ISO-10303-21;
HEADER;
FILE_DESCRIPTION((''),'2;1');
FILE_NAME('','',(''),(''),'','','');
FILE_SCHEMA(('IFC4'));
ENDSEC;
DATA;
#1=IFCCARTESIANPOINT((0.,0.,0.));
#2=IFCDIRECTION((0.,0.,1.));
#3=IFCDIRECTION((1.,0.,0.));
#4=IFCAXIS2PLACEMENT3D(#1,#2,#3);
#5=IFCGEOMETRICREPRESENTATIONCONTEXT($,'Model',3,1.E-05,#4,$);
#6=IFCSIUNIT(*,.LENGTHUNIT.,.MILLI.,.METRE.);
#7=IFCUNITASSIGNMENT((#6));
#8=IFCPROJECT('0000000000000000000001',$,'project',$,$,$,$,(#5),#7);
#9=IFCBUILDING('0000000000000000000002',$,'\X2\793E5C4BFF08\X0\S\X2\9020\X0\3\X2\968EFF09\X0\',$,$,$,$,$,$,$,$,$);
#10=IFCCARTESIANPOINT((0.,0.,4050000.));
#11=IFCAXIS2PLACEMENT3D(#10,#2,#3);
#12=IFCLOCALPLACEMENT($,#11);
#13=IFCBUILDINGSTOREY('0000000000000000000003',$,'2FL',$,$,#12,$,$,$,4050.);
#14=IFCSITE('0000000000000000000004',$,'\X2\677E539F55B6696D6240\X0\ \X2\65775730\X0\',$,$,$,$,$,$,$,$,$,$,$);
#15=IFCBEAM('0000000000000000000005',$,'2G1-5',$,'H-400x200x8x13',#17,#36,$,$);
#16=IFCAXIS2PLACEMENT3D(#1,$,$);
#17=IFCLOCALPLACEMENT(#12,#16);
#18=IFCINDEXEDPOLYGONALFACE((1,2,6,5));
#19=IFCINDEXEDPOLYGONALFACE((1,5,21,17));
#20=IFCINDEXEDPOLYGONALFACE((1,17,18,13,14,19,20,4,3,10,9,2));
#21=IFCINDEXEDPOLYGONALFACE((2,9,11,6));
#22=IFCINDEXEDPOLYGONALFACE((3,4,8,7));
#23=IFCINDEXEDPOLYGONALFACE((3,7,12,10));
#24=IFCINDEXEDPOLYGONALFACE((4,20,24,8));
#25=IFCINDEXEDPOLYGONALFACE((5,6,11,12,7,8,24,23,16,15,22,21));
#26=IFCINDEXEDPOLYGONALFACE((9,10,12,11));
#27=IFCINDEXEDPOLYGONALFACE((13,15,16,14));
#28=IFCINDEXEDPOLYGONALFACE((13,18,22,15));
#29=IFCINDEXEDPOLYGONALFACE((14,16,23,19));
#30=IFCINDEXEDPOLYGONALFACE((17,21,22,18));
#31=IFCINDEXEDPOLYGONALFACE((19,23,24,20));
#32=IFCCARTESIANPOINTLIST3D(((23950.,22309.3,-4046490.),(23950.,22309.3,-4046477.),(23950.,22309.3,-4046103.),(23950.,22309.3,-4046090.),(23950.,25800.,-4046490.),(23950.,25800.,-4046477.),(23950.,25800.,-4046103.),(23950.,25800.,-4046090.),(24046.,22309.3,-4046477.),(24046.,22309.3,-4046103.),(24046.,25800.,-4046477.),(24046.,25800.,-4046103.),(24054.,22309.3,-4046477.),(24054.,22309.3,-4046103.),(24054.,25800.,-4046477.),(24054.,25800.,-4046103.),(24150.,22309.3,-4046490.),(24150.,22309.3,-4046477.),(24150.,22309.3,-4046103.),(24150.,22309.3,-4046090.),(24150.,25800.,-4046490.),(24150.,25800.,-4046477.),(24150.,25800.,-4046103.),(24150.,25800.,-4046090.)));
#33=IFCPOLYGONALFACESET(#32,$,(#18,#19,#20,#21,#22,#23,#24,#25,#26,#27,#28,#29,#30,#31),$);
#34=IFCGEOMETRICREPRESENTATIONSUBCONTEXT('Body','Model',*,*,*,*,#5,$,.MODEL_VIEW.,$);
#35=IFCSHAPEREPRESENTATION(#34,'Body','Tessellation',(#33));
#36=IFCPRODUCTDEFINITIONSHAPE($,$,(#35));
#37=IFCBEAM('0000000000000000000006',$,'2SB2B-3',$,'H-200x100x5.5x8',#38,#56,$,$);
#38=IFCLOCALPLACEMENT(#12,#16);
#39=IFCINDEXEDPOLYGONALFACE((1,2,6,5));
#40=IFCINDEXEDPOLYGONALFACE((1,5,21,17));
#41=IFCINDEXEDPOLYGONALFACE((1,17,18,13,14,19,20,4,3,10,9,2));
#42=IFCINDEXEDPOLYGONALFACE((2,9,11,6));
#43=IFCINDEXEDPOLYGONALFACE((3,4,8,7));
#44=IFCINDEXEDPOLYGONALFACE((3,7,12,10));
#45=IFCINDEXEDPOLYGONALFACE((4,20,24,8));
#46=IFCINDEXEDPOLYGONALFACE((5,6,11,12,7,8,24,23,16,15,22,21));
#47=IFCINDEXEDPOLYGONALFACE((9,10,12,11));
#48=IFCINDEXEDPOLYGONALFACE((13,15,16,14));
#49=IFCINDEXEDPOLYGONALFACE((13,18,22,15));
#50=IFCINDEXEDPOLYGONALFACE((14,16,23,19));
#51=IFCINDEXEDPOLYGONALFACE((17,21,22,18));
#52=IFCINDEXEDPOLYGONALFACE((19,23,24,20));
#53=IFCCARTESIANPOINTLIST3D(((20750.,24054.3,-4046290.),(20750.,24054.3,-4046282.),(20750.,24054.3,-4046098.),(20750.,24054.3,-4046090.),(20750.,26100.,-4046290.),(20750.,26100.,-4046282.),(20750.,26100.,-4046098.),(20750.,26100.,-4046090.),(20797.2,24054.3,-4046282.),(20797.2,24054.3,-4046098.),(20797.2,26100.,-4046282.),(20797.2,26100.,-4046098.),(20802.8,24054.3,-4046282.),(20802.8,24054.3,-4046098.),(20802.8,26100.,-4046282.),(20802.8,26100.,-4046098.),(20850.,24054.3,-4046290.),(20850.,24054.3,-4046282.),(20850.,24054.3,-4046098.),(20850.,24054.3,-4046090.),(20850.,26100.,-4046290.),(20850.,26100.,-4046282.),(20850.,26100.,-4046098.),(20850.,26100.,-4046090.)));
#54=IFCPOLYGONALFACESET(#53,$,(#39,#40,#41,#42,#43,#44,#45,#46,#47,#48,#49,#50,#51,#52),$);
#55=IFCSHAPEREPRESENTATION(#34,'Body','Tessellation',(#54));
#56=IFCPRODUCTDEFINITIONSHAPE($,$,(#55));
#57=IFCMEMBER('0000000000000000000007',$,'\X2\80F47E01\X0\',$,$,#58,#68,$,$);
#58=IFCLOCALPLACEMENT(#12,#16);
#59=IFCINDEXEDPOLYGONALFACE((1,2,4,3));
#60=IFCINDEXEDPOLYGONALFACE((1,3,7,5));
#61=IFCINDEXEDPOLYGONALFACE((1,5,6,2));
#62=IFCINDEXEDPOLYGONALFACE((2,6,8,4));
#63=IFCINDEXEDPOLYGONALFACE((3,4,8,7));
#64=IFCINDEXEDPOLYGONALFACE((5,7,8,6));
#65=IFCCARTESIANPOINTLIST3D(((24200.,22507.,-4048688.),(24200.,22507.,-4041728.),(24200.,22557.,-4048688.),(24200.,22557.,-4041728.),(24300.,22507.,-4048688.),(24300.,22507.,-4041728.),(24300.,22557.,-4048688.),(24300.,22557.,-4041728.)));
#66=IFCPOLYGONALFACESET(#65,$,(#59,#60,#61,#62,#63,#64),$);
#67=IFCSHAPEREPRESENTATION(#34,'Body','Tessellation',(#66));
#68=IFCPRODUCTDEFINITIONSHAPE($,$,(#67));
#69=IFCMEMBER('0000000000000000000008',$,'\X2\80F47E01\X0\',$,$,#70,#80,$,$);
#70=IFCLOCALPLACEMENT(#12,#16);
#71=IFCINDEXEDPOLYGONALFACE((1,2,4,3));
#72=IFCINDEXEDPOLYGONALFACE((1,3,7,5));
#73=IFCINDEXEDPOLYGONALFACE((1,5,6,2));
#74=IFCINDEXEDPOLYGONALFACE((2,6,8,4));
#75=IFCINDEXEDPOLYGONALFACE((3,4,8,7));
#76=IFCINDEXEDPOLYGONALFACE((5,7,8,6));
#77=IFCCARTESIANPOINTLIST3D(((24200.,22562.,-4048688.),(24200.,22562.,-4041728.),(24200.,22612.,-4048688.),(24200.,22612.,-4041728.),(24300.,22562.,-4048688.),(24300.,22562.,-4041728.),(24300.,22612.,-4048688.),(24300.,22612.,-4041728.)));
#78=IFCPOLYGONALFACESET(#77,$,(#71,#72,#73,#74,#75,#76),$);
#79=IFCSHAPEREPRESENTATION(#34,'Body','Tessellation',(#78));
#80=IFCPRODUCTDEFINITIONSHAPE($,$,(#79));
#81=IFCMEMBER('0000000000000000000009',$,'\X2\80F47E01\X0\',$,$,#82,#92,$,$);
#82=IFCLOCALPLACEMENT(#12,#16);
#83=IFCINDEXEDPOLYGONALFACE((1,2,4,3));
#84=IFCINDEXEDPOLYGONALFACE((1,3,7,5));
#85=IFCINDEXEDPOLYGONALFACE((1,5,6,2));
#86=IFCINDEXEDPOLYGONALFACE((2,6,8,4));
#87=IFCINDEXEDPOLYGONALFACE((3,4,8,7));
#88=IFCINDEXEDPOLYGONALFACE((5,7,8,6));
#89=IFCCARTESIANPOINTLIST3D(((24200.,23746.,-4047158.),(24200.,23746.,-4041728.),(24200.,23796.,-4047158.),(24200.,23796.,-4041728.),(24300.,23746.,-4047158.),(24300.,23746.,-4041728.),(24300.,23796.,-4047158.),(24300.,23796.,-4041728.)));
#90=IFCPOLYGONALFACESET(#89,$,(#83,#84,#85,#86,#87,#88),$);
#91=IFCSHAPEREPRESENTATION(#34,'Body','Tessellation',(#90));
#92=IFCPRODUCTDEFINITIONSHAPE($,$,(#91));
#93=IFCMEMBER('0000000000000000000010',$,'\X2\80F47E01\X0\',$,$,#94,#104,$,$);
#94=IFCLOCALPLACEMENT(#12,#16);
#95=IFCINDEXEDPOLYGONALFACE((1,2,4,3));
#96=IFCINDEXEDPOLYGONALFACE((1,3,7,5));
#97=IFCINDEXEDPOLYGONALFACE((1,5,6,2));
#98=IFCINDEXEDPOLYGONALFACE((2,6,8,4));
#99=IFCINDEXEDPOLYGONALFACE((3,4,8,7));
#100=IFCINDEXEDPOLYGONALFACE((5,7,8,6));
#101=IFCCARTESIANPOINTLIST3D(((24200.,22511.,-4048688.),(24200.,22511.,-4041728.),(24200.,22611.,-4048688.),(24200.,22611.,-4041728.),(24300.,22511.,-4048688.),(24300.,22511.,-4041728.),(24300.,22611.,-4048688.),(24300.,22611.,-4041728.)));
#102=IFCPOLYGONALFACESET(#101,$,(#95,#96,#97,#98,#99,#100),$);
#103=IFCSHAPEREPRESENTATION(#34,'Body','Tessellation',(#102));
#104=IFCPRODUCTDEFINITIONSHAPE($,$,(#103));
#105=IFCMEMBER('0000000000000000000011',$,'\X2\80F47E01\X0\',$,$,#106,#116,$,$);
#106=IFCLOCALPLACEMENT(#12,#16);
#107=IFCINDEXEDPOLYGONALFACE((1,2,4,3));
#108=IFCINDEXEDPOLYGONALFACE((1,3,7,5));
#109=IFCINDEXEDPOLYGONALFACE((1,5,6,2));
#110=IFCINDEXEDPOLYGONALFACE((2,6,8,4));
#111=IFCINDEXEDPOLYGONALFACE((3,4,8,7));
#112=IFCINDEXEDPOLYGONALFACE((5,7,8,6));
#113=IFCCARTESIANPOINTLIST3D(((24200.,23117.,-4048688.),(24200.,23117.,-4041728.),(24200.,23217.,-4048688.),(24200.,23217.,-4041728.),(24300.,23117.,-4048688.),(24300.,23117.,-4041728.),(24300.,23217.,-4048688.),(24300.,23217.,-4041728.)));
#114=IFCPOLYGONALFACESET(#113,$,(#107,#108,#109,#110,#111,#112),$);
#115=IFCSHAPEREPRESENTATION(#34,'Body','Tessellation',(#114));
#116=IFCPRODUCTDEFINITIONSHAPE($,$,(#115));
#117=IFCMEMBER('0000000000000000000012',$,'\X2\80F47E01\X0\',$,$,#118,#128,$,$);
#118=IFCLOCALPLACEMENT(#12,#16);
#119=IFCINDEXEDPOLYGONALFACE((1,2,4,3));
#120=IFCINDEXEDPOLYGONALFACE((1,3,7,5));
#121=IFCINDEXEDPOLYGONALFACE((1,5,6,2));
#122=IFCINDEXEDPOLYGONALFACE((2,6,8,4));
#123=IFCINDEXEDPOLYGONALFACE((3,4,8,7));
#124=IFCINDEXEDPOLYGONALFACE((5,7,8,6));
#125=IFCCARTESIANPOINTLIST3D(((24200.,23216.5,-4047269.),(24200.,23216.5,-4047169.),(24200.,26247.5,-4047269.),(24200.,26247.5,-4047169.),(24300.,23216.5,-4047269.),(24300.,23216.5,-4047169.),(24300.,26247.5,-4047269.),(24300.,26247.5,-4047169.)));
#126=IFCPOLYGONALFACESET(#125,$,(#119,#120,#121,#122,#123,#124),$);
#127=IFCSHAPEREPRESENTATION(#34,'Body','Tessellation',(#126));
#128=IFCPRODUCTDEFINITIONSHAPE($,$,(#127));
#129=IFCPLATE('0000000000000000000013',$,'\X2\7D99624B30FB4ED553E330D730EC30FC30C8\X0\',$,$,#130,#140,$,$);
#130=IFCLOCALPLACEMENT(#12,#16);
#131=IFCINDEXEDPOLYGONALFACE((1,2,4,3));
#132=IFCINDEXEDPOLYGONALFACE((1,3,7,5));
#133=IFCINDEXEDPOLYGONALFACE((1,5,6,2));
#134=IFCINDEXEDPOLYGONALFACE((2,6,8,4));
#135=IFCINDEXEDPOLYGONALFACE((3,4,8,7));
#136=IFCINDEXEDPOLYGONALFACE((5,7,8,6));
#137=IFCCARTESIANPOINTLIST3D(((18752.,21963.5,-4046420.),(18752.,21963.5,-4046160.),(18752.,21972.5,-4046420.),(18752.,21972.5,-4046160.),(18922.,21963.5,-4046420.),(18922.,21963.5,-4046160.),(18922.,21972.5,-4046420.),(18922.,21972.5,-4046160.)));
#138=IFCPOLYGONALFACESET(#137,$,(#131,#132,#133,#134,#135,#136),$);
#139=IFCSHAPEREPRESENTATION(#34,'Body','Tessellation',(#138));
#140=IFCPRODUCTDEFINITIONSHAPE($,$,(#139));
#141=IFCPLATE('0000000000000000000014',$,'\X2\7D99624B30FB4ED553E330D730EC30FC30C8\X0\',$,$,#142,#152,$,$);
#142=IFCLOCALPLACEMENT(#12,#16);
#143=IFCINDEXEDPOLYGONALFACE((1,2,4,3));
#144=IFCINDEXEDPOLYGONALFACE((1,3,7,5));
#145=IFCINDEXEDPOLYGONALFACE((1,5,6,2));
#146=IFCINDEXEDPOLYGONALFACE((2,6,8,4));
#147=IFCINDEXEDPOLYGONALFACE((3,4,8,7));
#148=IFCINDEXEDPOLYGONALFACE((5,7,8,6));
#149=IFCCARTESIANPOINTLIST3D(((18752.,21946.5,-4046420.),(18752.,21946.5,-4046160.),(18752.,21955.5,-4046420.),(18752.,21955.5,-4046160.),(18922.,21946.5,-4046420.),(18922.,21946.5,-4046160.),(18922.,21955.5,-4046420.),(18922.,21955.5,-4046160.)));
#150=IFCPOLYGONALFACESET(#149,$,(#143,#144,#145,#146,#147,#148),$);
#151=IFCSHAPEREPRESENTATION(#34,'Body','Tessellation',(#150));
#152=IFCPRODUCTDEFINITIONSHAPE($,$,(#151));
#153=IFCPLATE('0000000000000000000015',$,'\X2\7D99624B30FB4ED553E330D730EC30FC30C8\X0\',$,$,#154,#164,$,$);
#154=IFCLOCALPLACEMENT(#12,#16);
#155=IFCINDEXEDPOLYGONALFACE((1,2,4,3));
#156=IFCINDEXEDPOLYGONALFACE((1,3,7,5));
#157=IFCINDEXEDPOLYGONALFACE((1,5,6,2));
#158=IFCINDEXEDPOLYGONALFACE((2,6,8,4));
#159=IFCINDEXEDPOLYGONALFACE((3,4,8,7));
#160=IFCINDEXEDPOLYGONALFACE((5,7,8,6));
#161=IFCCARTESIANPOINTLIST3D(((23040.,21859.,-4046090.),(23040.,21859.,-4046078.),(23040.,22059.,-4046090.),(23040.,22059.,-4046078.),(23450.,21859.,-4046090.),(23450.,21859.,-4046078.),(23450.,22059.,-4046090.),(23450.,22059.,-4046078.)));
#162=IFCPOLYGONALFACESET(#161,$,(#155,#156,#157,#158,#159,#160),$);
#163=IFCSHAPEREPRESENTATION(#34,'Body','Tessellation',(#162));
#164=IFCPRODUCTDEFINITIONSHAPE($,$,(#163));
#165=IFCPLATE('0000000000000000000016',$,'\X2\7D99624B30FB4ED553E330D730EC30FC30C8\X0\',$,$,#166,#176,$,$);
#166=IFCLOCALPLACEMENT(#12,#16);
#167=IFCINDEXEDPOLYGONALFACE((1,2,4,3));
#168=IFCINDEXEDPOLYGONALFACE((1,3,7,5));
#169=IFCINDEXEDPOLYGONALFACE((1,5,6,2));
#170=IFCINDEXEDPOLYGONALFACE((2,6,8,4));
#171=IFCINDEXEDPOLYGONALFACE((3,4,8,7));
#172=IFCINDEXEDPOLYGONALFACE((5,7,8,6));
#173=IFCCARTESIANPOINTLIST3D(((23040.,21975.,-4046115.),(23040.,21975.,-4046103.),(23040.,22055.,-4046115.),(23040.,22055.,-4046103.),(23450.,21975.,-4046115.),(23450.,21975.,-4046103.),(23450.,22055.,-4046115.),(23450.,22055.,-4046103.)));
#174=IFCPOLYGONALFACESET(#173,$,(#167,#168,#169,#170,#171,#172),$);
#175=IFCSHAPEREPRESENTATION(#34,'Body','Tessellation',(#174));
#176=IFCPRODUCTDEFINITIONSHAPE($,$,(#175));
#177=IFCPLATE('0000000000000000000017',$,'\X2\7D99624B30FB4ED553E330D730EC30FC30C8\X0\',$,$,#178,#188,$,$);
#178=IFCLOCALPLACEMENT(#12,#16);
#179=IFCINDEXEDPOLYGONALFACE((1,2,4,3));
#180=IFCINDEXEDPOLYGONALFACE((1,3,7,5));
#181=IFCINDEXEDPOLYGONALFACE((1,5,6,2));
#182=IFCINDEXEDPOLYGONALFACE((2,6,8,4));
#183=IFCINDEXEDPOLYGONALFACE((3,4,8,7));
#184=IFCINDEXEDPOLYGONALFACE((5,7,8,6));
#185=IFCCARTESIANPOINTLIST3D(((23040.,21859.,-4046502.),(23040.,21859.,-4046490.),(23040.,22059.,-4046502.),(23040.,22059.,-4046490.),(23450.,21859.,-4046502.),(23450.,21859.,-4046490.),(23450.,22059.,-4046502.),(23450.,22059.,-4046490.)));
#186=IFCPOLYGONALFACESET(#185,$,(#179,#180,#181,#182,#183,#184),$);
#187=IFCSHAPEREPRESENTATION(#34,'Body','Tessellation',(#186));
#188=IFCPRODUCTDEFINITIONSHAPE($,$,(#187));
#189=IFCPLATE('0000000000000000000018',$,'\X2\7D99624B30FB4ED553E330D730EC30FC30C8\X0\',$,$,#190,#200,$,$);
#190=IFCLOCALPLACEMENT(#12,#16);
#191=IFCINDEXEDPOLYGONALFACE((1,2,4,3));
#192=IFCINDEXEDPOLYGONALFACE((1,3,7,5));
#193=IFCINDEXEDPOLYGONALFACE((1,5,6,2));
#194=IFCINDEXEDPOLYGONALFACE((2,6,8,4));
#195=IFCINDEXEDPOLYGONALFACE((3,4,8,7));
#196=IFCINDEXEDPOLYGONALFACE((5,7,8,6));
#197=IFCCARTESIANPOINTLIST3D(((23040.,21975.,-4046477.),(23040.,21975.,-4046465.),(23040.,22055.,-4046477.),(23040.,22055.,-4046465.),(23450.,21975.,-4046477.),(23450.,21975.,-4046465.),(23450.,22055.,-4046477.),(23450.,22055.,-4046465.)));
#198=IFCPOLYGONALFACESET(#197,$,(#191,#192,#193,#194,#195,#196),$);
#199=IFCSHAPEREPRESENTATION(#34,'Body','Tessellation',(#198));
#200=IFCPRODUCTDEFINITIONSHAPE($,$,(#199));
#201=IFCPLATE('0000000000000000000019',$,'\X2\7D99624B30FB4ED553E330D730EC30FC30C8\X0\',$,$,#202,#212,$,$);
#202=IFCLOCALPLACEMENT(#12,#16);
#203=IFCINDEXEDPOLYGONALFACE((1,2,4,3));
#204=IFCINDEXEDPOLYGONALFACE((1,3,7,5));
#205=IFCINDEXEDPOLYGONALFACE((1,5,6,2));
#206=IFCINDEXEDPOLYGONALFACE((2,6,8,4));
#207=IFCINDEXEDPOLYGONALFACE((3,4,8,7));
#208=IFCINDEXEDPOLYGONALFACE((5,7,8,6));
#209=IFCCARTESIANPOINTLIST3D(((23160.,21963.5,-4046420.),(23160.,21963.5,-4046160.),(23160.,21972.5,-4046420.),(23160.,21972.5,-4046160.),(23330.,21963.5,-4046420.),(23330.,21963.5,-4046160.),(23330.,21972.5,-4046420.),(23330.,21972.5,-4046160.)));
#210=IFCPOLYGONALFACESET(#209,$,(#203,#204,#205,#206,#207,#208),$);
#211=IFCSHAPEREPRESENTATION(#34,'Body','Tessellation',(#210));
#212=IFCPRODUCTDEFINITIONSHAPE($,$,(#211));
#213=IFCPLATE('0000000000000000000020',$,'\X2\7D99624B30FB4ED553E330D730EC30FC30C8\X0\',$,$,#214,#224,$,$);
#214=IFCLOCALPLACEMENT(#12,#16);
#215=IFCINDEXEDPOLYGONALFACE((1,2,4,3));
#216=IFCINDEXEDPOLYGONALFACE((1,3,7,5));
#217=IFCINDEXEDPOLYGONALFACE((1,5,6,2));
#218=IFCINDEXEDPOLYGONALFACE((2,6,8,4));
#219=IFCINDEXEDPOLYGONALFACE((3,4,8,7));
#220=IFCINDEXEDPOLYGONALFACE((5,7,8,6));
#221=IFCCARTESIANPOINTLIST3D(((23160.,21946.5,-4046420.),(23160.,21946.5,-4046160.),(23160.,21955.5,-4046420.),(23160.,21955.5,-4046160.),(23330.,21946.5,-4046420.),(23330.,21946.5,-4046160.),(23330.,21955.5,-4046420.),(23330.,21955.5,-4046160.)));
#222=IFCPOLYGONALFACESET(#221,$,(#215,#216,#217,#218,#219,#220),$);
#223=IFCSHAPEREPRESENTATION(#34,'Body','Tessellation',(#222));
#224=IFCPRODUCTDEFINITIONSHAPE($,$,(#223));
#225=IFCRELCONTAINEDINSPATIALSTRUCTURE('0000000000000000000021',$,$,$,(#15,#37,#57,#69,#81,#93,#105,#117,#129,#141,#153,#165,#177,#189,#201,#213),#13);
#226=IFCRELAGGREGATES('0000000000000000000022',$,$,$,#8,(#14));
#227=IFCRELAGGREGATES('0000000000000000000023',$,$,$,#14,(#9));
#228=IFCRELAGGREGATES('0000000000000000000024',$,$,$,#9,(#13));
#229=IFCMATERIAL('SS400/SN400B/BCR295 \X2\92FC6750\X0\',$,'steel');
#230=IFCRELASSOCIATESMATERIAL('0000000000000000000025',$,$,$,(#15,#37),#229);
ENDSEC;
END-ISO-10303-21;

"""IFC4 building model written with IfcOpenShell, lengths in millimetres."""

from ifc_helpers import new_model, si_unit, frame, origin, origin_with_axes, place, context, subcontext, project, spatial, rectangle, i_section, extrude, material, element, save


model = new_model("IFC4")

# Units and contexts
model_context = context("Model", 3, precision=1e-05, world=origin_with_axes())
body_context = subcontext(model_context, "Body", "Model", "MODEL_VIEW")
ifc_project = project(units=[si_unit("LENGTHUNIT", "METRE", prefix="MILLI")], contexts=[model_context])

# Site, building, storey
site = spatial("IfcSite", under=ifc_project, Name="松原営業所 敷地")
building = spatial("IfcBuilding", under=site, Name="社屋（S造3階）")
storey_placement = place(None, frame((0.0, 0.0, 4050000.0), z_axis=(0.0, 0.0, 1.0), x_axis=(1.0, 0.0, 0.0)))
storey = spatial("IfcBuildingStorey", under=building, at=storey_placement, Name="2FL", Elevation=4050.0)

# Beams
ifc_material = material(Name="SS400/SN400B/BCR295 鋼材", Category="steel")
beam_1_placement = place(storey_placement, frame((24050.0, 22309.3, -4046090.0), z_axis=(0.0, 1.0, 0.0), x_axis=(-1.0, 0.0, 0.0)))
element("IfcBeam", 1, at=beam_1_placement, inside=storey, material=ifc_material, Name="2G1-5", ObjectType="H-400x200x8x13", context=body_context, shape_type="SweptSolid", body=[
    extrude(i_section(OverallWidth=200.0, OverallDepth=400.0, WebThickness=8.0, FlangeThickness=13.0), frame((0.0, -200.0, 0.0)), (0.0, 0.0, 1.0), 3490.7),
])
beam_2_placement = place(storey_placement, frame((20800.0, 24054.3, -4046090.0), z_axis=(0.0, 1.0, 0.0), x_axis=(-1.0, 0.0, 0.0)))
element("IfcBeam", 2, at=beam_2_placement, inside=storey, material=ifc_material, Name="2SB2B-3", ObjectType="H-200x100x5.5x8", context=body_context, shape_type="SweptSolid", body=[
    extrude(i_section(OverallWidth=100.0, OverallDepth=200.0, WebThickness=5.5, FlangeThickness=8.0), frame((0.0, -100.0, 0.0)), (0.0, 0.0, 1.0), 2045.7),
])

# Members
for number, where, z_axis, x_axis, name in (
    (3, (24250.0, 22507.0, -4045208.0), (0.0, 1.0, 0.0), (-1.0, 0.0, 0.0), "胴縁"),
    (4, (24250.0, 22562.0, -4045208.0), (0.0, 1.0, 0.0), (-1.0, 0.0, 0.0), "胴縁"),
):
    element("IfcMember", number, at=place(storey_placement, frame(where, z_axis=z_axis, x_axis=x_axis)), inside=storey, Name=name, context=body_context, shape_type="SweptSolid", body=[
        extrude(rectangle(XDim=100.0, YDim=6960.0), origin(), (0.0, 0.0, 1.0), 50.0),
    ])
member_1_placement = place(storey_placement, frame((24250.0, 23746.0, -4044443.0), z_axis=(0.0, 1.0, 0.0), x_axis=(-1.0, 0.0, 0.0)))
element("IfcMember", 5, at=member_1_placement, inside=storey, Name="胴縁", context=body_context, shape_type="SweptSolid", body=[
    extrude(rectangle(XDim=100.0, YDim=5430.0), origin(), (0.0, 0.0, 1.0), 50.0),
])
for number, where, z_axis, x_axis, name in (
    (6, (24250.0, 22511.0, -4045208.0), (0.0, 1.0, 0.0), (-1.0, 0.0, 0.0), "胴縁"),
    (7, (24250.0, 23117.0, -4045208.0), (0.0, 1.0, 0.0), (-1.0, 0.0, 0.0), "胴縁"),
):
    element("IfcMember", number, at=place(storey_placement, frame(where, z_axis=z_axis, x_axis=x_axis)), inside=storey, Name=name, context=body_context, shape_type="SweptSolid", body=[
        extrude(rectangle(XDim=100.0, YDim=6960.0), origin(), (0.0, 0.0, 1.0), 100.0),
    ])
member_2_placement = place(storey_placement, frame((24250.0, 23216.5, -4047219.0), z_axis=(0.0, 1.0, 0.0), x_axis=(-1.0, 0.0, 0.0)))
element("IfcMember", 8, at=member_2_placement, inside=storey, Name="胴縁", context=body_context, shape_type="SweptSolid", body=[
    extrude(rectangle(XDim=100.0, YDim=100.0), origin(), (0.0, 0.0, 1.0), 3031.0),
])

# Plates
for number, where, z_axis, x_axis, name in (
    (9, (18752.0, 21968.0, -4046290.0), (1.0, 0.0, 0.0), (0.0, 1.0, 0.0), "継手・仕口プレート"),
    (10, (18752.0, 21951.0, -4046290.0), (1.0, 0.0, 0.0), (0.0, 1.0, 0.0), "継手・仕口プレート"),
):
    element("IfcPlate", number, at=place(storey_placement, frame(where, z_axis=z_axis, x_axis=x_axis)), inside=storey, Name=name, context=body_context, shape_type="SweptSolid", body=[
        extrude(rectangle(XDim=9.0, YDim=260.0), origin(), (0.0, 0.0, 1.0), 170.0),
    ])
plate_1_placement = place(storey_placement, frame((23040.0, 21959.0, -4046084.0), z_axis=(1.0, 0.0, 0.0), x_axis=(0.0, 1.0, 0.0)))
element("IfcPlate", 11, at=plate_1_placement, inside=storey, Name="継手・仕口プレート", context=body_context, shape_type="SweptSolid", body=[
    extrude(rectangle(XDim=200.0, YDim=12.0), origin(), (0.0, 0.0, 1.0), 410.0),
])
plate_2_placement = place(storey_placement, frame((23040.0, 22015.0, -4046109.0), z_axis=(1.0, 0.0, 0.0), x_axis=(0.0, 1.0, 0.0)))
element("IfcPlate", 12, at=plate_2_placement, inside=storey, Name="継手・仕口プレート", context=body_context, shape_type="SweptSolid", body=[
    extrude(rectangle(XDim=80.0, YDim=12.0), origin(), (0.0, 0.0, 1.0), 410.0),
])
plate_3_placement = place(storey_placement, frame((23040.0, 21959.0, -4046496.0), z_axis=(1.0, 0.0, 0.0), x_axis=(0.0, 1.0, 0.0)))
element("IfcPlate", 13, at=plate_3_placement, inside=storey, Name="継手・仕口プレート", context=body_context, shape_type="SweptSolid", body=[
    extrude(rectangle(XDim=200.0, YDim=12.0), origin(), (0.0, 0.0, 1.0), 410.0),
])
plate_4_placement = place(storey_placement, frame((23040.0, 22015.0, -4046471.0), z_axis=(1.0, 0.0, 0.0), x_axis=(0.0, 1.0, 0.0)))
element("IfcPlate", 14, at=plate_4_placement, inside=storey, Name="継手・仕口プレート", context=body_context, shape_type="SweptSolid", body=[
    extrude(rectangle(XDim=80.0, YDim=12.0), origin(), (0.0, 0.0, 1.0), 410.0),
])
for number, where, z_axis, x_axis, name in (
    (15, (23160.0, 21968.0, -4046290.0), (1.0, 0.0, 0.0), (0.0, 1.0, 0.0), "継手・仕口プレート"),
    (16, (23160.0, 21951.0, -4046290.0), (1.0, 0.0, 0.0), (0.0, 1.0, 0.0), "継手・仕口プレート"),
):
    element("IfcPlate", number, at=place(storey_placement, frame(where, z_axis=z_axis, x_axis=x_axis)), inside=storey, Name=name, context=body_context, shape_type="SweptSolid", body=[
        extrude(rectangle(XDim=9.0, YDim=260.0), origin(), (0.0, 0.0, 1.0), 170.0),
    ])

save(model, "model.ifc")
